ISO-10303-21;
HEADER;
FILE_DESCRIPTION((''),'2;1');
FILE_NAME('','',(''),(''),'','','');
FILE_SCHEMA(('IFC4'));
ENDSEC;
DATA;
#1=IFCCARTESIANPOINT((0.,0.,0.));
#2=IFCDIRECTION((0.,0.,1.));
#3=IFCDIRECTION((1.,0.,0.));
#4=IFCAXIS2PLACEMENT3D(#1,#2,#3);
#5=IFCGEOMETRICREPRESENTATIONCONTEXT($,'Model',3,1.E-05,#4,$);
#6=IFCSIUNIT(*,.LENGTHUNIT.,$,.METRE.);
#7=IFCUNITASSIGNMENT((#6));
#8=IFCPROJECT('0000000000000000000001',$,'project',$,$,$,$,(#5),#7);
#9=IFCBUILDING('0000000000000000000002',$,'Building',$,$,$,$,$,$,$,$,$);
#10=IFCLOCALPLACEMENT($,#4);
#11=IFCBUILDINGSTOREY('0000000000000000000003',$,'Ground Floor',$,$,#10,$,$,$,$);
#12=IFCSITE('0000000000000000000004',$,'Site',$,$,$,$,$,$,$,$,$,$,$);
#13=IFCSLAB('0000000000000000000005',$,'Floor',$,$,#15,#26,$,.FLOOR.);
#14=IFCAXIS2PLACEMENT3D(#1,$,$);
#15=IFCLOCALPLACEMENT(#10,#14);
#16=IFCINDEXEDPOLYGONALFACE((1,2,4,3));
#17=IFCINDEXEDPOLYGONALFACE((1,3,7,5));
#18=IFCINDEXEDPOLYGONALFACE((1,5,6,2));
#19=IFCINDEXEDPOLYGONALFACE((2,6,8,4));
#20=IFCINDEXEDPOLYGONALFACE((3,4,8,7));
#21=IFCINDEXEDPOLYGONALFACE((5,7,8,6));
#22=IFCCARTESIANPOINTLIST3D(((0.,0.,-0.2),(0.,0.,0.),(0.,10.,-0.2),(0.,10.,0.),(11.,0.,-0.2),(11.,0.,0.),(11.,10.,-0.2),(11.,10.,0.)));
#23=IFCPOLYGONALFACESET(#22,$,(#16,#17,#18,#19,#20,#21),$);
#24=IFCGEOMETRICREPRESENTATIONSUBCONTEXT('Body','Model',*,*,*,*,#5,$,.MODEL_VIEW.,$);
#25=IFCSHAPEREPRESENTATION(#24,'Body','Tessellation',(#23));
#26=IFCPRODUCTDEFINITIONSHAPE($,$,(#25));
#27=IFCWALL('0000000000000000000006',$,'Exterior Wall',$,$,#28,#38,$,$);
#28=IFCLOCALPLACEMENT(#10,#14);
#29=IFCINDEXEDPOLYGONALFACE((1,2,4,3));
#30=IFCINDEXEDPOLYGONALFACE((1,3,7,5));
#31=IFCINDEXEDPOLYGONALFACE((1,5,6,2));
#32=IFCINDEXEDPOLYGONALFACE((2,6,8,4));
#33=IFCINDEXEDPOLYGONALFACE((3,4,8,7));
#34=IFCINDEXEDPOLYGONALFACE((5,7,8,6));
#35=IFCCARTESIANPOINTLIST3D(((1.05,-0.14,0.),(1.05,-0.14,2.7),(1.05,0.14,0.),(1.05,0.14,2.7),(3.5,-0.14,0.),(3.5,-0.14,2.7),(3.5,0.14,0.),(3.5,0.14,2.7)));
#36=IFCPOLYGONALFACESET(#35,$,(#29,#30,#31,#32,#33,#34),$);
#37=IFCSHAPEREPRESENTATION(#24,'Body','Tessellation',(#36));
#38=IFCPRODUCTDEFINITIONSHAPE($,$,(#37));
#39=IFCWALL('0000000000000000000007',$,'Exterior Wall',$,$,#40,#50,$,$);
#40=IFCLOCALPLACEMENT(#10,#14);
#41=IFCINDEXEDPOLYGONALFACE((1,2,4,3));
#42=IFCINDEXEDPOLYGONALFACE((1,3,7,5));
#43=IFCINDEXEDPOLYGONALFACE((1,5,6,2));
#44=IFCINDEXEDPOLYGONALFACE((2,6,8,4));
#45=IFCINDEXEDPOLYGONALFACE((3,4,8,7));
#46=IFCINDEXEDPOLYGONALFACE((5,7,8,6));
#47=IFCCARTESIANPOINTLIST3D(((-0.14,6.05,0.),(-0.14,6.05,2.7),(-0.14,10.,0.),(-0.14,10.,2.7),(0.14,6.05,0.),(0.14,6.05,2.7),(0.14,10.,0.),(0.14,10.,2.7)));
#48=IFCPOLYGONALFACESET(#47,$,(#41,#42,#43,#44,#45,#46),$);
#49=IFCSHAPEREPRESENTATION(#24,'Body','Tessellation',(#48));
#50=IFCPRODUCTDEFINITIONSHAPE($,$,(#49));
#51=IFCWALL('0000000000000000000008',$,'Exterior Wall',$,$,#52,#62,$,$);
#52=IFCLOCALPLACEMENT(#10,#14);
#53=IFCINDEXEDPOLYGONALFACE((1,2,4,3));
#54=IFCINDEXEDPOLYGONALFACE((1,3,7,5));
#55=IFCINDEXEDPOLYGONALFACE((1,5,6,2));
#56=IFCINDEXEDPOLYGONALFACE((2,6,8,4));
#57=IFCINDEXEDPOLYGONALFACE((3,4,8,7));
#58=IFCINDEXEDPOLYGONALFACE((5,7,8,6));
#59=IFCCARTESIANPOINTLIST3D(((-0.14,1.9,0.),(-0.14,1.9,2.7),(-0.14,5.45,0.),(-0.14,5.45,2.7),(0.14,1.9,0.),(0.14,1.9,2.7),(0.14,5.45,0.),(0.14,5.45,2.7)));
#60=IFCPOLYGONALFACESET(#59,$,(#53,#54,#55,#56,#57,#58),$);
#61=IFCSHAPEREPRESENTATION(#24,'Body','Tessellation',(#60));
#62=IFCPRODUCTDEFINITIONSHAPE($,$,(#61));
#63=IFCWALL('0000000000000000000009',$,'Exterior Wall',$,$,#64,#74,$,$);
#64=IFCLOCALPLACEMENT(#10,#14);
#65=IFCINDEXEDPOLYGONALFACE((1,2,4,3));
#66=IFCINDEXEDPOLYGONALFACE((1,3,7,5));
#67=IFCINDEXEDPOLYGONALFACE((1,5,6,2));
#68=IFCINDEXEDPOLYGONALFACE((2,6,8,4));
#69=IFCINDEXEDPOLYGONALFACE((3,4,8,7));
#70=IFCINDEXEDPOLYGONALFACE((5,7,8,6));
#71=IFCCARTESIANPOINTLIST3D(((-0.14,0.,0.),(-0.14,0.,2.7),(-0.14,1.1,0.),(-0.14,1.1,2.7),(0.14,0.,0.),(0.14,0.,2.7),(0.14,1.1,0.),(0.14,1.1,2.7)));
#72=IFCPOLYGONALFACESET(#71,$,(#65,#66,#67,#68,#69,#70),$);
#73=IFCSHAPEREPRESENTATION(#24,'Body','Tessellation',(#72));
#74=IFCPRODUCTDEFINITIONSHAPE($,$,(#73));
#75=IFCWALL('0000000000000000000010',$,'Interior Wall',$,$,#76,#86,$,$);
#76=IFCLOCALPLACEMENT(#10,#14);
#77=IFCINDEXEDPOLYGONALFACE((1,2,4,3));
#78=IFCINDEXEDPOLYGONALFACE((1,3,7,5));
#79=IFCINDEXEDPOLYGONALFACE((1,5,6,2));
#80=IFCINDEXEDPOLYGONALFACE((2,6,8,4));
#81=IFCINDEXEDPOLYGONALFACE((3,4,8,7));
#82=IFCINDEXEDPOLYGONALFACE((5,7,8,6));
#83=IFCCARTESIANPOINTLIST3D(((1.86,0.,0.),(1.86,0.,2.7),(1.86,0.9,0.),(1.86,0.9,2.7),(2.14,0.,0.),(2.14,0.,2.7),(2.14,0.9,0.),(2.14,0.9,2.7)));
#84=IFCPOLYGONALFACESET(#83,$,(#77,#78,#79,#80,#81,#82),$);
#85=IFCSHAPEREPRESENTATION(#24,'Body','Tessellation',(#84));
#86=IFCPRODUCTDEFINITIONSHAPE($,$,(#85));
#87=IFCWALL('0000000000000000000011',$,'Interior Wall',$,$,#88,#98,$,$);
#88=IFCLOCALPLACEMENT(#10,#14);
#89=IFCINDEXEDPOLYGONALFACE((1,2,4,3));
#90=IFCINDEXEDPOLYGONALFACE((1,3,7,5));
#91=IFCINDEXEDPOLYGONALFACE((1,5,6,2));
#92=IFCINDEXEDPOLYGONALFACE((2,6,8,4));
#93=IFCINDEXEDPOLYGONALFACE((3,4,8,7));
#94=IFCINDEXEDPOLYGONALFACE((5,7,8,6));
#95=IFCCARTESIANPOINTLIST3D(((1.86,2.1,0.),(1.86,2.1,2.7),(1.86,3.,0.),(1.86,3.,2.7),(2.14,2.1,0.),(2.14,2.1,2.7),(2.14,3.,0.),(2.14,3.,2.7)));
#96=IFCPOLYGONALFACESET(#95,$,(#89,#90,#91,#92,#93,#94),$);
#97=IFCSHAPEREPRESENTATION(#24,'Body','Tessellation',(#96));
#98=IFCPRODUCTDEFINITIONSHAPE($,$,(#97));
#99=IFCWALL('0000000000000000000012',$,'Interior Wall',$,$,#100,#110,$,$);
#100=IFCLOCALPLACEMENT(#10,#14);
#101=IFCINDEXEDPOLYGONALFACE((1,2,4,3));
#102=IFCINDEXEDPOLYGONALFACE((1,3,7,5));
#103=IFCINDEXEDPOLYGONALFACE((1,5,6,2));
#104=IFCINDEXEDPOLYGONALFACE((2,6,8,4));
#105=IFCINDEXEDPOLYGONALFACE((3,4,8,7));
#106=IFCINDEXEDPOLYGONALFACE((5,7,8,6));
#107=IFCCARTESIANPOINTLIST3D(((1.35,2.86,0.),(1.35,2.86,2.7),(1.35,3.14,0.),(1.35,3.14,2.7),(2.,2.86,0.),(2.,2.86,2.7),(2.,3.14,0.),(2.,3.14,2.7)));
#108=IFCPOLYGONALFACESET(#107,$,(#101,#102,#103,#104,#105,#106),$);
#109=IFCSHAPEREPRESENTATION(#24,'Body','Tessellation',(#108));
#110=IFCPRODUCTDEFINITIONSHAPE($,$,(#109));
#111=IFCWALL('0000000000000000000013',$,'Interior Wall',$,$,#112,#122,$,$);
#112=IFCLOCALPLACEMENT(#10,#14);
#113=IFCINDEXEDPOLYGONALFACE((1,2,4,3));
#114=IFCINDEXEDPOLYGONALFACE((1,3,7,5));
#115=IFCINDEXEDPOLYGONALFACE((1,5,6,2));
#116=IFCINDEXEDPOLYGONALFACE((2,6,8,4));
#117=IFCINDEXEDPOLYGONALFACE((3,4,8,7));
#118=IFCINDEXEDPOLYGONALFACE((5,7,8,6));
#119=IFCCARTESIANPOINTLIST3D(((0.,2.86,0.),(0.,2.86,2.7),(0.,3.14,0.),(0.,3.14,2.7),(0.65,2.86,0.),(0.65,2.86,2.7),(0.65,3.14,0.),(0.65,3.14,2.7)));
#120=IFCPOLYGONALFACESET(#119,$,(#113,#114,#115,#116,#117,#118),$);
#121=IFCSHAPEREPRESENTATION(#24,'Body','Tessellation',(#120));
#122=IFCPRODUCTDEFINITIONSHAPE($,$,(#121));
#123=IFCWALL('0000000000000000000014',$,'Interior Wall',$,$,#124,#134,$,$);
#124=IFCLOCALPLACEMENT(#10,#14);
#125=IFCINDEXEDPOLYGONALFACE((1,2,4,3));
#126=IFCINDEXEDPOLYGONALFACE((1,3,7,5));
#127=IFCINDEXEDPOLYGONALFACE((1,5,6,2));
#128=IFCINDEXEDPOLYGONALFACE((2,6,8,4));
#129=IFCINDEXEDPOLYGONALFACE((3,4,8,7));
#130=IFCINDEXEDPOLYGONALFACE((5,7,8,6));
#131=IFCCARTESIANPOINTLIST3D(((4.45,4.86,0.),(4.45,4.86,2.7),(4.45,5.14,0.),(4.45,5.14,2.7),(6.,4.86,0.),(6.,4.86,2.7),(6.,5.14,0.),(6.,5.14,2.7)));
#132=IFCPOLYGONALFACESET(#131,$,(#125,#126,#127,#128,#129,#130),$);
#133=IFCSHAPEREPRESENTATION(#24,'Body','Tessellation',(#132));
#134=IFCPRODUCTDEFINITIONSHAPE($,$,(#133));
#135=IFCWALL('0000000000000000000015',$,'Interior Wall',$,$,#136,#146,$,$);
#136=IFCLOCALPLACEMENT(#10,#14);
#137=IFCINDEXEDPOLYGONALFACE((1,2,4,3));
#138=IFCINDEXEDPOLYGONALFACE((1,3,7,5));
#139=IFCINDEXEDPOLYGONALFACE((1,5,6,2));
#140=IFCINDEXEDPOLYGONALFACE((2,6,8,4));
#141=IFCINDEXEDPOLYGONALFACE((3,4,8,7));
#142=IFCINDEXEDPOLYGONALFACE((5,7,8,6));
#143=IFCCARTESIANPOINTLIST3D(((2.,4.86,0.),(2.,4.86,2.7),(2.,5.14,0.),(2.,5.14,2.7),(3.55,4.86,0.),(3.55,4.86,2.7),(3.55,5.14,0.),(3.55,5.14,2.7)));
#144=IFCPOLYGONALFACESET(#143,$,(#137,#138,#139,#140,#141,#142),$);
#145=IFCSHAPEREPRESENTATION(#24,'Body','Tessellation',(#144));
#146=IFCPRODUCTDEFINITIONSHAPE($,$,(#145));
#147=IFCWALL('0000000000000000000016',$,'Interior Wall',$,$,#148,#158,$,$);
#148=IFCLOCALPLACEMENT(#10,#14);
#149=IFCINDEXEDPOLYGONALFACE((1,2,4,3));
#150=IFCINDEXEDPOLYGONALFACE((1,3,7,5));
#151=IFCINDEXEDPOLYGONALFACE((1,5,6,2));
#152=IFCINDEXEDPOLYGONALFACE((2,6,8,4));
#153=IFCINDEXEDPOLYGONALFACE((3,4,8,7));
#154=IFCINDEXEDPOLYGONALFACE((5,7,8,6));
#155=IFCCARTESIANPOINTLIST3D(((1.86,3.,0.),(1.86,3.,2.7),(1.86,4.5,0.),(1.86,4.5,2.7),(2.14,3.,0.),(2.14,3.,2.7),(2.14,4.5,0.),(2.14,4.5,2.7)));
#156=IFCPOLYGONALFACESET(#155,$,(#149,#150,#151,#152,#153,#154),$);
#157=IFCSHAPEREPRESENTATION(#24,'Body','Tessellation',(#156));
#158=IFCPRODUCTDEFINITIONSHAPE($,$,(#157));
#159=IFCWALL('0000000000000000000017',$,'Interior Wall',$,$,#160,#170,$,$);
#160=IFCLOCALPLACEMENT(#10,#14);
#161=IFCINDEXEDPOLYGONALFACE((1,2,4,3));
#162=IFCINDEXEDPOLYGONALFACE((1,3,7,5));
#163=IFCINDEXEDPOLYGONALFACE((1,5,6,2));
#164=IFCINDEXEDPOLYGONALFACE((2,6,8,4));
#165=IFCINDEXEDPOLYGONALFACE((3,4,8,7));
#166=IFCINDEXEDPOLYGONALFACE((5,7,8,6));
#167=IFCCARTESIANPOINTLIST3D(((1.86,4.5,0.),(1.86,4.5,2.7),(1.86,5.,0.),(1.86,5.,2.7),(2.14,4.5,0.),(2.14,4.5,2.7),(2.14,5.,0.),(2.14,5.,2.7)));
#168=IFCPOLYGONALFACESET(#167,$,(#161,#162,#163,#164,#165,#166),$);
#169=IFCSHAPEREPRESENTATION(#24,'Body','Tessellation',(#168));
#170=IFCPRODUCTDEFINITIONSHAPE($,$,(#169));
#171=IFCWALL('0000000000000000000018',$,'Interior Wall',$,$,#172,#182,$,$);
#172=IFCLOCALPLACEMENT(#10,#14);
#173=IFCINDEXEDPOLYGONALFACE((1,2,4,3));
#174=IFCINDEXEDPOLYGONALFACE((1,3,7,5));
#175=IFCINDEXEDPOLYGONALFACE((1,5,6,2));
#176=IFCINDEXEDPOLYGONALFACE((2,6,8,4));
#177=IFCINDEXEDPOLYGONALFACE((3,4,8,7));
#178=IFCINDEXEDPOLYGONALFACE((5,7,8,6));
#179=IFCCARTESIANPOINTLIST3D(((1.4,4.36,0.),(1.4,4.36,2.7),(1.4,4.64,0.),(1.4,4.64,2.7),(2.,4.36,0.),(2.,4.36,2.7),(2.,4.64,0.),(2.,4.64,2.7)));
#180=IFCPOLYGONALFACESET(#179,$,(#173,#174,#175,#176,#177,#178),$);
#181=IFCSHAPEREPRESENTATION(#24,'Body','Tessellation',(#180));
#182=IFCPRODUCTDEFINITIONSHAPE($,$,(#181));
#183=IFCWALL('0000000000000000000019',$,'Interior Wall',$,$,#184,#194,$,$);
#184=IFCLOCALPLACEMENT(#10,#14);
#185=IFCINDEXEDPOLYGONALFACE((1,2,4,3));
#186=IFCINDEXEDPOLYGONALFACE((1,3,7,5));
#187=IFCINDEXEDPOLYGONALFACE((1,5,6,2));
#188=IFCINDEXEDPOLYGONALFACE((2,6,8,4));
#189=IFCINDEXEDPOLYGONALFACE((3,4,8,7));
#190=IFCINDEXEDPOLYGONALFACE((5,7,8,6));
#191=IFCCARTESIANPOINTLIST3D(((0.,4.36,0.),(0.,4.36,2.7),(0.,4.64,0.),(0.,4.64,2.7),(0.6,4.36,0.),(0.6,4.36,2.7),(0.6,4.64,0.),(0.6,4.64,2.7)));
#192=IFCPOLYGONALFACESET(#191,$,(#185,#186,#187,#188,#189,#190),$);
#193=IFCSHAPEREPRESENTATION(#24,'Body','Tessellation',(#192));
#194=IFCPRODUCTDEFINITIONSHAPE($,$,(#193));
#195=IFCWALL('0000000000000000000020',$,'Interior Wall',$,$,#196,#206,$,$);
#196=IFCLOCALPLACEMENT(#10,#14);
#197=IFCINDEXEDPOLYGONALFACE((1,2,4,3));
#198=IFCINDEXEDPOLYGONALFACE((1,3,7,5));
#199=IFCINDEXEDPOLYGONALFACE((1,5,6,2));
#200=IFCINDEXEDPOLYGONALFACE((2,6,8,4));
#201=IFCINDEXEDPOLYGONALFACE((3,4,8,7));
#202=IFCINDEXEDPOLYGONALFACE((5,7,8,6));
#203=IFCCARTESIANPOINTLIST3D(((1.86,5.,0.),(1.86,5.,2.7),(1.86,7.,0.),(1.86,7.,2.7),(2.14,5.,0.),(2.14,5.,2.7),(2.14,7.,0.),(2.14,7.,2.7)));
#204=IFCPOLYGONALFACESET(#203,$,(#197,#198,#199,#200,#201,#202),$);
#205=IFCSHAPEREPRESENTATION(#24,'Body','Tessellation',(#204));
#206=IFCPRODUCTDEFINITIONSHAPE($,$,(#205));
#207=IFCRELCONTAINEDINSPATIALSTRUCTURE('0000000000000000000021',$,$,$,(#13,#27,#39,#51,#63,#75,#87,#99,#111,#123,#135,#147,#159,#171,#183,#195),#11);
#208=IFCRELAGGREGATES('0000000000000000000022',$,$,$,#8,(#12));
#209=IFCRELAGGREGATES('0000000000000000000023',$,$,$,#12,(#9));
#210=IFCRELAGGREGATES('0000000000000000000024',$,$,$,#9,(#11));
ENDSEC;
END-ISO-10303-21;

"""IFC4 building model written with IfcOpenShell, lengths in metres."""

from ifc_helpers import new_model, si_unit, frame, origin_with_axes, place, context, subcontext, project, spatial, indexed_curve, outline, extrude, element, save


model = new_model("IFC4")

# Units and contexts
model_context = context("Model", 3, precision=1e-05, world=origin_with_axes())
body_context = subcontext(model_context, "Body", "Model", "MODEL_VIEW")
ifc_project = project(units=[si_unit("LENGTHUNIT", "METRE")], contexts=[model_context])

# Site, building, storey
site = spatial("IfcSite", under=ifc_project, Name="Site")
building = spatial("IfcBuilding", under=site, Name="Building")
storey_placement = place(None, origin_with_axes())
storey = spatial("IfcBuildingStorey", under=building, at=storey_placement, Name="Ground Floor")

# Slab
slab_placement = place(storey_placement, frame((0.0, 0.0, -0.2), z_axis=(0.0, 0.0, 1.0), x_axis=(1.0, 0.0, 0.0)))
element("IfcSlab", 1, at=slab_placement, inside=storey, Name="Floor", PredefinedType="FLOOR", context=body_context, shape_type="SweptSolid", body=[
    extrude(outline(indexed_curve([(0.0, 0.0), (11.0, 0.0), (11.0, 10.0), (0.0, 10.0)])), None, (0.0, 0.0, 1.0), 0.2),
])

# Walls
wall_1_placement = place(storey_placement, frame((1.05, 0.0, 0.0), z_axis=(0.0, 0.0, 1.0), x_axis=(1.0, 0.0, 0.0)))
element("IfcWall", 2, at=wall_1_placement, inside=storey, Name="Exterior Wall", context=body_context, shape_type="SweptSolid", body=[
    extrude(outline(indexed_curve([(0.0, 0.0), (0.0, 0.28), (2.45, 0.28), (2.45, 0.0), (0.0, 0.0)], self_intersect=False)), frame((0.0, -0.14, 0.0), z_axis=(0.0, 0.0, 1.0), x_axis=(1.0, 0.0, 0.0)), (0.0, 0.0, 1.0), 2.7),
])
wall_2_placement = place(storey_placement, frame((0.0, 10.0, 0.0), z_axis=(0.0, 0.0, 1.0), x_axis=(0.0, -1.0, 0.0)))
element("IfcWall", 3, at=wall_2_placement, inside=storey, Name="Exterior Wall", context=body_context, shape_type="SweptSolid", body=[
    extrude(outline(indexed_curve([(0.0, 0.0), (0.0, 0.28), (3.95, 0.28), (3.95, 0.0), (0.0, 0.0)], self_intersect=False)), frame((0.0, -0.14, 0.0), z_axis=(0.0, 0.0, 1.0), x_axis=(1.0, 0.0, 0.0)), (0.0, 0.0, 1.0), 2.7),
])
wall_3_placement = place(storey_placement, frame((0.0, 5.45, 0.0), z_axis=(0.0, 0.0, 1.0), x_axis=(0.0, -1.0, 0.0)))
element("IfcWall", 4, at=wall_3_placement, inside=storey, Name="Exterior Wall", context=body_context, shape_type="SweptSolid", body=[
    extrude(outline(indexed_curve([(0.0, 0.0), (0.0, 0.28), (3.55, 0.28), (3.55, 0.0), (0.0, 0.0)], self_intersect=False)), frame((0.0, -0.14, 0.0), z_axis=(0.0, 0.0, 1.0), x_axis=(1.0, 0.0, 0.0)), (0.0, 0.0, 1.0), 2.7),
])
wall_4_placement = place(storey_placement, frame((0.0, 1.1, 0.0), z_axis=(0.0, 0.0, 1.0), x_axis=(0.0, -1.0, 0.0)))
element("IfcWall", 5, at=wall_4_placement, inside=storey, Name="Exterior Wall", context=body_context, shape_type="SweptSolid", body=[
    extrude(outline(indexed_curve([(0.0, 0.0), (0.0, 0.28), (1.1, 0.28), (1.1, 0.0), (0.0, 0.0)], self_intersect=False)), frame((0.0, -0.14, 0.0), z_axis=(0.0, 0.0, 1.0), x_axis=(1.0, 0.0, 0.0)), (0.0, 0.0, 1.0), 2.7),
])
wall_5_placement = place(storey_placement, frame((2.0, 0.0, 0.0), z_axis=(0.0, 0.0, 1.0), x_axis=(0.0, 1.0, 0.0)))
element("IfcWall", 6, at=wall_5_placement, inside=storey, Name="Interior Wall", context=body_context, shape_type="SweptSolid", body=[
    extrude(outline(indexed_curve([(0.0, 0.0), (0.0, 0.28), (0.9, 0.28), (0.9, 0.0), (0.0, 0.0)], self_intersect=False)), frame((0.0, -0.14, 0.0), z_axis=(0.0, 0.0, 1.0), x_axis=(1.0, 0.0, 0.0)), (0.0, 0.0, 1.0), 2.7),
])
wall_6_placement = place(storey_placement, frame((2.0, 2.1, 0.0), z_axis=(0.0, 0.0, 1.0), x_axis=(0.0, 1.0, 0.0)))
element("IfcWall", 7, at=wall_6_placement, inside=storey, Name="Interior Wall", context=body_context, shape_type="SweptSolid", body=[
    extrude(outline(indexed_curve([(0.0, 0.0), (0.0, 0.28), (0.9, 0.28), (0.9, 0.0), (0.0, 0.0)], self_intersect=False)), frame((0.0, -0.14, 0.0), z_axis=(0.0, 0.0, 1.0), x_axis=(1.0, 0.0, 0.0)), (0.0, 0.0, 1.0), 2.7),
])
for number, where, z_axis, x_axis, name in (
    (8, (2.0, 3.0, 0.0), (0.0, 0.0, 1.0), (-1.0, 0.0, 0.0), "Interior Wall"),
    (9, (0.65, 3.0, 0.0), (0.0, 0.0, 1.0), (-1.0, 0.0, 0.0), "Interior Wall"),
):
    element("IfcWall", number, at=place(storey_placement, frame(where, z_axis=z_axis, x_axis=x_axis)), inside=storey, Name=name, context=body_context, shape_type="SweptSolid", body=[
        extrude(outline(indexed_curve([(0.0, 0.0), (0.0, 0.28), (0.65, 0.28), (0.65, 0.0), (0.0, 0.0)], self_intersect=False)), frame((0.0, -0.14, 0.0), z_axis=(0.0, 0.0, 1.0), x_axis=(1.0, 0.0, 0.0)), (0.0, 0.0, 1.0), 2.7),
    ])
for number, where, z_axis, x_axis, name in (
    (10, (6.0, 5.0, 0.0), (0.0, 0.0, 1.0), (-1.0, 0.0, 0.0), "Interior Wall"),
    (11, (3.55, 5.0, 0.0), (0.0, 0.0, 1.0), (-1.0, 0.0, 0.0), "Interior Wall"),
):
    element("IfcWall", number, at=place(storey_placement, frame(where, z_axis=z_axis, x_axis=x_axis)), inside=storey, Name=name, context=body_context, shape_type="SweptSolid", body=[
        extrude(outline(indexed_curve([(0.0, 0.0), (0.0, 0.28), (1.55, 0.28), (1.55, 0.0), (0.0, 0.0)], self_intersect=False)), frame((0.0, -0.14, 0.0), z_axis=(0.0, 0.0, 1.0), x_axis=(1.0, 0.0, 0.0)), (0.0, 0.0, 1.0), 2.7),
    ])
wall_7_placement = place(storey_placement, frame((2.0, 4.5, 0.0), z_axis=(0.0, 0.0, 1.0), x_axis=(0.0, -1.0, 0.0)))
element("IfcWall", 12, at=wall_7_placement, inside=storey, Name="Interior Wall", context=body_context, shape_type="SweptSolid", body=[
    extrude(outline(indexed_curve([(0.0, 0.0), (0.0, 0.28), (1.5, 0.28), (1.5, 0.0), (0.0, 0.0)], self_intersect=False)), frame((0.0, -0.14, 0.0), z_axis=(0.0, 0.0, 1.0), x_axis=(1.0, 0.0, 0.0)), (0.0, 0.0, 1.0), 2.7),
])
wall_8_placement = place(storey_placement, frame((2.0, 5.0, 0.0), z_axis=(0.0, 0.0, 1.0), x_axis=(0.0, -1.0, 0.0)))
element("IfcWall", 13, at=wall_8_placement, inside=storey, Name="Interior Wall", context=body_context, shape_type="SweptSolid", body=[
    extrude(outline(indexed_curve([(0.0, 0.0), (0.0, 0.28), (0.5, 0.28), (0.5, 0.0), (0.0, 0.0)], self_intersect=False)), frame((0.0, -0.14, 0.0), z_axis=(0.0, 0.0, 1.0), x_axis=(1.0, 0.0, 0.0)), (0.0, 0.0, 1.0), 2.7),
])
for number, where, z_axis, x_axis, name in (
    (14, (2.0, 4.5, 0.0), (0.0, 0.0, 1.0), (-1.0, 0.0, 0.0), "Interior Wall"),
    (15, (0.6, 4.5, 0.0), (0.0, 0.0, 1.0), (-1.0, 0.0, 0.0), "Interior Wall"),
):
    element("IfcWall", number, at=place(storey_placement, frame(where, z_axis=z_axis, x_axis=x_axis)), inside=storey, Name=name, context=body_context, shape_type="SweptSolid", body=[
        extrude(outline(indexed_curve([(0.0, 0.0), (0.0, 0.28), (0.6, 0.28), (0.6, 0.0), (0.0, 0.0)], self_intersect=False)), frame((0.0, -0.14, 0.0), z_axis=(0.0, 0.0, 1.0), x_axis=(1.0, 0.0, 0.0)), (0.0, 0.0, 1.0), 2.7),
    ])
wall_9_placement = place(storey_placement, frame((2.0, 5.0, 0.0), z_axis=(0.0, 0.0, 1.0), x_axis=(0.0, 1.0, 0.0)))
element("IfcWall", 16, at=wall_9_placement, inside=storey, Name="Interior Wall", context=body_context, shape_type="SweptSolid", body=[
    extrude(outline(indexed_curve([(0.0, 0.0), (0.0, 0.28), (2.0, 0.28), (2.0, 0.0), (0.0, 0.0)], self_intersect=False)), frame((0.0, -0.14, 0.0), z_axis=(0.0, 0.0, 1.0), x_axis=(1.0, 0.0, 0.0)), (0.0, 0.0, 1.0), 2.7),
])

save(model, "model.ifc")
